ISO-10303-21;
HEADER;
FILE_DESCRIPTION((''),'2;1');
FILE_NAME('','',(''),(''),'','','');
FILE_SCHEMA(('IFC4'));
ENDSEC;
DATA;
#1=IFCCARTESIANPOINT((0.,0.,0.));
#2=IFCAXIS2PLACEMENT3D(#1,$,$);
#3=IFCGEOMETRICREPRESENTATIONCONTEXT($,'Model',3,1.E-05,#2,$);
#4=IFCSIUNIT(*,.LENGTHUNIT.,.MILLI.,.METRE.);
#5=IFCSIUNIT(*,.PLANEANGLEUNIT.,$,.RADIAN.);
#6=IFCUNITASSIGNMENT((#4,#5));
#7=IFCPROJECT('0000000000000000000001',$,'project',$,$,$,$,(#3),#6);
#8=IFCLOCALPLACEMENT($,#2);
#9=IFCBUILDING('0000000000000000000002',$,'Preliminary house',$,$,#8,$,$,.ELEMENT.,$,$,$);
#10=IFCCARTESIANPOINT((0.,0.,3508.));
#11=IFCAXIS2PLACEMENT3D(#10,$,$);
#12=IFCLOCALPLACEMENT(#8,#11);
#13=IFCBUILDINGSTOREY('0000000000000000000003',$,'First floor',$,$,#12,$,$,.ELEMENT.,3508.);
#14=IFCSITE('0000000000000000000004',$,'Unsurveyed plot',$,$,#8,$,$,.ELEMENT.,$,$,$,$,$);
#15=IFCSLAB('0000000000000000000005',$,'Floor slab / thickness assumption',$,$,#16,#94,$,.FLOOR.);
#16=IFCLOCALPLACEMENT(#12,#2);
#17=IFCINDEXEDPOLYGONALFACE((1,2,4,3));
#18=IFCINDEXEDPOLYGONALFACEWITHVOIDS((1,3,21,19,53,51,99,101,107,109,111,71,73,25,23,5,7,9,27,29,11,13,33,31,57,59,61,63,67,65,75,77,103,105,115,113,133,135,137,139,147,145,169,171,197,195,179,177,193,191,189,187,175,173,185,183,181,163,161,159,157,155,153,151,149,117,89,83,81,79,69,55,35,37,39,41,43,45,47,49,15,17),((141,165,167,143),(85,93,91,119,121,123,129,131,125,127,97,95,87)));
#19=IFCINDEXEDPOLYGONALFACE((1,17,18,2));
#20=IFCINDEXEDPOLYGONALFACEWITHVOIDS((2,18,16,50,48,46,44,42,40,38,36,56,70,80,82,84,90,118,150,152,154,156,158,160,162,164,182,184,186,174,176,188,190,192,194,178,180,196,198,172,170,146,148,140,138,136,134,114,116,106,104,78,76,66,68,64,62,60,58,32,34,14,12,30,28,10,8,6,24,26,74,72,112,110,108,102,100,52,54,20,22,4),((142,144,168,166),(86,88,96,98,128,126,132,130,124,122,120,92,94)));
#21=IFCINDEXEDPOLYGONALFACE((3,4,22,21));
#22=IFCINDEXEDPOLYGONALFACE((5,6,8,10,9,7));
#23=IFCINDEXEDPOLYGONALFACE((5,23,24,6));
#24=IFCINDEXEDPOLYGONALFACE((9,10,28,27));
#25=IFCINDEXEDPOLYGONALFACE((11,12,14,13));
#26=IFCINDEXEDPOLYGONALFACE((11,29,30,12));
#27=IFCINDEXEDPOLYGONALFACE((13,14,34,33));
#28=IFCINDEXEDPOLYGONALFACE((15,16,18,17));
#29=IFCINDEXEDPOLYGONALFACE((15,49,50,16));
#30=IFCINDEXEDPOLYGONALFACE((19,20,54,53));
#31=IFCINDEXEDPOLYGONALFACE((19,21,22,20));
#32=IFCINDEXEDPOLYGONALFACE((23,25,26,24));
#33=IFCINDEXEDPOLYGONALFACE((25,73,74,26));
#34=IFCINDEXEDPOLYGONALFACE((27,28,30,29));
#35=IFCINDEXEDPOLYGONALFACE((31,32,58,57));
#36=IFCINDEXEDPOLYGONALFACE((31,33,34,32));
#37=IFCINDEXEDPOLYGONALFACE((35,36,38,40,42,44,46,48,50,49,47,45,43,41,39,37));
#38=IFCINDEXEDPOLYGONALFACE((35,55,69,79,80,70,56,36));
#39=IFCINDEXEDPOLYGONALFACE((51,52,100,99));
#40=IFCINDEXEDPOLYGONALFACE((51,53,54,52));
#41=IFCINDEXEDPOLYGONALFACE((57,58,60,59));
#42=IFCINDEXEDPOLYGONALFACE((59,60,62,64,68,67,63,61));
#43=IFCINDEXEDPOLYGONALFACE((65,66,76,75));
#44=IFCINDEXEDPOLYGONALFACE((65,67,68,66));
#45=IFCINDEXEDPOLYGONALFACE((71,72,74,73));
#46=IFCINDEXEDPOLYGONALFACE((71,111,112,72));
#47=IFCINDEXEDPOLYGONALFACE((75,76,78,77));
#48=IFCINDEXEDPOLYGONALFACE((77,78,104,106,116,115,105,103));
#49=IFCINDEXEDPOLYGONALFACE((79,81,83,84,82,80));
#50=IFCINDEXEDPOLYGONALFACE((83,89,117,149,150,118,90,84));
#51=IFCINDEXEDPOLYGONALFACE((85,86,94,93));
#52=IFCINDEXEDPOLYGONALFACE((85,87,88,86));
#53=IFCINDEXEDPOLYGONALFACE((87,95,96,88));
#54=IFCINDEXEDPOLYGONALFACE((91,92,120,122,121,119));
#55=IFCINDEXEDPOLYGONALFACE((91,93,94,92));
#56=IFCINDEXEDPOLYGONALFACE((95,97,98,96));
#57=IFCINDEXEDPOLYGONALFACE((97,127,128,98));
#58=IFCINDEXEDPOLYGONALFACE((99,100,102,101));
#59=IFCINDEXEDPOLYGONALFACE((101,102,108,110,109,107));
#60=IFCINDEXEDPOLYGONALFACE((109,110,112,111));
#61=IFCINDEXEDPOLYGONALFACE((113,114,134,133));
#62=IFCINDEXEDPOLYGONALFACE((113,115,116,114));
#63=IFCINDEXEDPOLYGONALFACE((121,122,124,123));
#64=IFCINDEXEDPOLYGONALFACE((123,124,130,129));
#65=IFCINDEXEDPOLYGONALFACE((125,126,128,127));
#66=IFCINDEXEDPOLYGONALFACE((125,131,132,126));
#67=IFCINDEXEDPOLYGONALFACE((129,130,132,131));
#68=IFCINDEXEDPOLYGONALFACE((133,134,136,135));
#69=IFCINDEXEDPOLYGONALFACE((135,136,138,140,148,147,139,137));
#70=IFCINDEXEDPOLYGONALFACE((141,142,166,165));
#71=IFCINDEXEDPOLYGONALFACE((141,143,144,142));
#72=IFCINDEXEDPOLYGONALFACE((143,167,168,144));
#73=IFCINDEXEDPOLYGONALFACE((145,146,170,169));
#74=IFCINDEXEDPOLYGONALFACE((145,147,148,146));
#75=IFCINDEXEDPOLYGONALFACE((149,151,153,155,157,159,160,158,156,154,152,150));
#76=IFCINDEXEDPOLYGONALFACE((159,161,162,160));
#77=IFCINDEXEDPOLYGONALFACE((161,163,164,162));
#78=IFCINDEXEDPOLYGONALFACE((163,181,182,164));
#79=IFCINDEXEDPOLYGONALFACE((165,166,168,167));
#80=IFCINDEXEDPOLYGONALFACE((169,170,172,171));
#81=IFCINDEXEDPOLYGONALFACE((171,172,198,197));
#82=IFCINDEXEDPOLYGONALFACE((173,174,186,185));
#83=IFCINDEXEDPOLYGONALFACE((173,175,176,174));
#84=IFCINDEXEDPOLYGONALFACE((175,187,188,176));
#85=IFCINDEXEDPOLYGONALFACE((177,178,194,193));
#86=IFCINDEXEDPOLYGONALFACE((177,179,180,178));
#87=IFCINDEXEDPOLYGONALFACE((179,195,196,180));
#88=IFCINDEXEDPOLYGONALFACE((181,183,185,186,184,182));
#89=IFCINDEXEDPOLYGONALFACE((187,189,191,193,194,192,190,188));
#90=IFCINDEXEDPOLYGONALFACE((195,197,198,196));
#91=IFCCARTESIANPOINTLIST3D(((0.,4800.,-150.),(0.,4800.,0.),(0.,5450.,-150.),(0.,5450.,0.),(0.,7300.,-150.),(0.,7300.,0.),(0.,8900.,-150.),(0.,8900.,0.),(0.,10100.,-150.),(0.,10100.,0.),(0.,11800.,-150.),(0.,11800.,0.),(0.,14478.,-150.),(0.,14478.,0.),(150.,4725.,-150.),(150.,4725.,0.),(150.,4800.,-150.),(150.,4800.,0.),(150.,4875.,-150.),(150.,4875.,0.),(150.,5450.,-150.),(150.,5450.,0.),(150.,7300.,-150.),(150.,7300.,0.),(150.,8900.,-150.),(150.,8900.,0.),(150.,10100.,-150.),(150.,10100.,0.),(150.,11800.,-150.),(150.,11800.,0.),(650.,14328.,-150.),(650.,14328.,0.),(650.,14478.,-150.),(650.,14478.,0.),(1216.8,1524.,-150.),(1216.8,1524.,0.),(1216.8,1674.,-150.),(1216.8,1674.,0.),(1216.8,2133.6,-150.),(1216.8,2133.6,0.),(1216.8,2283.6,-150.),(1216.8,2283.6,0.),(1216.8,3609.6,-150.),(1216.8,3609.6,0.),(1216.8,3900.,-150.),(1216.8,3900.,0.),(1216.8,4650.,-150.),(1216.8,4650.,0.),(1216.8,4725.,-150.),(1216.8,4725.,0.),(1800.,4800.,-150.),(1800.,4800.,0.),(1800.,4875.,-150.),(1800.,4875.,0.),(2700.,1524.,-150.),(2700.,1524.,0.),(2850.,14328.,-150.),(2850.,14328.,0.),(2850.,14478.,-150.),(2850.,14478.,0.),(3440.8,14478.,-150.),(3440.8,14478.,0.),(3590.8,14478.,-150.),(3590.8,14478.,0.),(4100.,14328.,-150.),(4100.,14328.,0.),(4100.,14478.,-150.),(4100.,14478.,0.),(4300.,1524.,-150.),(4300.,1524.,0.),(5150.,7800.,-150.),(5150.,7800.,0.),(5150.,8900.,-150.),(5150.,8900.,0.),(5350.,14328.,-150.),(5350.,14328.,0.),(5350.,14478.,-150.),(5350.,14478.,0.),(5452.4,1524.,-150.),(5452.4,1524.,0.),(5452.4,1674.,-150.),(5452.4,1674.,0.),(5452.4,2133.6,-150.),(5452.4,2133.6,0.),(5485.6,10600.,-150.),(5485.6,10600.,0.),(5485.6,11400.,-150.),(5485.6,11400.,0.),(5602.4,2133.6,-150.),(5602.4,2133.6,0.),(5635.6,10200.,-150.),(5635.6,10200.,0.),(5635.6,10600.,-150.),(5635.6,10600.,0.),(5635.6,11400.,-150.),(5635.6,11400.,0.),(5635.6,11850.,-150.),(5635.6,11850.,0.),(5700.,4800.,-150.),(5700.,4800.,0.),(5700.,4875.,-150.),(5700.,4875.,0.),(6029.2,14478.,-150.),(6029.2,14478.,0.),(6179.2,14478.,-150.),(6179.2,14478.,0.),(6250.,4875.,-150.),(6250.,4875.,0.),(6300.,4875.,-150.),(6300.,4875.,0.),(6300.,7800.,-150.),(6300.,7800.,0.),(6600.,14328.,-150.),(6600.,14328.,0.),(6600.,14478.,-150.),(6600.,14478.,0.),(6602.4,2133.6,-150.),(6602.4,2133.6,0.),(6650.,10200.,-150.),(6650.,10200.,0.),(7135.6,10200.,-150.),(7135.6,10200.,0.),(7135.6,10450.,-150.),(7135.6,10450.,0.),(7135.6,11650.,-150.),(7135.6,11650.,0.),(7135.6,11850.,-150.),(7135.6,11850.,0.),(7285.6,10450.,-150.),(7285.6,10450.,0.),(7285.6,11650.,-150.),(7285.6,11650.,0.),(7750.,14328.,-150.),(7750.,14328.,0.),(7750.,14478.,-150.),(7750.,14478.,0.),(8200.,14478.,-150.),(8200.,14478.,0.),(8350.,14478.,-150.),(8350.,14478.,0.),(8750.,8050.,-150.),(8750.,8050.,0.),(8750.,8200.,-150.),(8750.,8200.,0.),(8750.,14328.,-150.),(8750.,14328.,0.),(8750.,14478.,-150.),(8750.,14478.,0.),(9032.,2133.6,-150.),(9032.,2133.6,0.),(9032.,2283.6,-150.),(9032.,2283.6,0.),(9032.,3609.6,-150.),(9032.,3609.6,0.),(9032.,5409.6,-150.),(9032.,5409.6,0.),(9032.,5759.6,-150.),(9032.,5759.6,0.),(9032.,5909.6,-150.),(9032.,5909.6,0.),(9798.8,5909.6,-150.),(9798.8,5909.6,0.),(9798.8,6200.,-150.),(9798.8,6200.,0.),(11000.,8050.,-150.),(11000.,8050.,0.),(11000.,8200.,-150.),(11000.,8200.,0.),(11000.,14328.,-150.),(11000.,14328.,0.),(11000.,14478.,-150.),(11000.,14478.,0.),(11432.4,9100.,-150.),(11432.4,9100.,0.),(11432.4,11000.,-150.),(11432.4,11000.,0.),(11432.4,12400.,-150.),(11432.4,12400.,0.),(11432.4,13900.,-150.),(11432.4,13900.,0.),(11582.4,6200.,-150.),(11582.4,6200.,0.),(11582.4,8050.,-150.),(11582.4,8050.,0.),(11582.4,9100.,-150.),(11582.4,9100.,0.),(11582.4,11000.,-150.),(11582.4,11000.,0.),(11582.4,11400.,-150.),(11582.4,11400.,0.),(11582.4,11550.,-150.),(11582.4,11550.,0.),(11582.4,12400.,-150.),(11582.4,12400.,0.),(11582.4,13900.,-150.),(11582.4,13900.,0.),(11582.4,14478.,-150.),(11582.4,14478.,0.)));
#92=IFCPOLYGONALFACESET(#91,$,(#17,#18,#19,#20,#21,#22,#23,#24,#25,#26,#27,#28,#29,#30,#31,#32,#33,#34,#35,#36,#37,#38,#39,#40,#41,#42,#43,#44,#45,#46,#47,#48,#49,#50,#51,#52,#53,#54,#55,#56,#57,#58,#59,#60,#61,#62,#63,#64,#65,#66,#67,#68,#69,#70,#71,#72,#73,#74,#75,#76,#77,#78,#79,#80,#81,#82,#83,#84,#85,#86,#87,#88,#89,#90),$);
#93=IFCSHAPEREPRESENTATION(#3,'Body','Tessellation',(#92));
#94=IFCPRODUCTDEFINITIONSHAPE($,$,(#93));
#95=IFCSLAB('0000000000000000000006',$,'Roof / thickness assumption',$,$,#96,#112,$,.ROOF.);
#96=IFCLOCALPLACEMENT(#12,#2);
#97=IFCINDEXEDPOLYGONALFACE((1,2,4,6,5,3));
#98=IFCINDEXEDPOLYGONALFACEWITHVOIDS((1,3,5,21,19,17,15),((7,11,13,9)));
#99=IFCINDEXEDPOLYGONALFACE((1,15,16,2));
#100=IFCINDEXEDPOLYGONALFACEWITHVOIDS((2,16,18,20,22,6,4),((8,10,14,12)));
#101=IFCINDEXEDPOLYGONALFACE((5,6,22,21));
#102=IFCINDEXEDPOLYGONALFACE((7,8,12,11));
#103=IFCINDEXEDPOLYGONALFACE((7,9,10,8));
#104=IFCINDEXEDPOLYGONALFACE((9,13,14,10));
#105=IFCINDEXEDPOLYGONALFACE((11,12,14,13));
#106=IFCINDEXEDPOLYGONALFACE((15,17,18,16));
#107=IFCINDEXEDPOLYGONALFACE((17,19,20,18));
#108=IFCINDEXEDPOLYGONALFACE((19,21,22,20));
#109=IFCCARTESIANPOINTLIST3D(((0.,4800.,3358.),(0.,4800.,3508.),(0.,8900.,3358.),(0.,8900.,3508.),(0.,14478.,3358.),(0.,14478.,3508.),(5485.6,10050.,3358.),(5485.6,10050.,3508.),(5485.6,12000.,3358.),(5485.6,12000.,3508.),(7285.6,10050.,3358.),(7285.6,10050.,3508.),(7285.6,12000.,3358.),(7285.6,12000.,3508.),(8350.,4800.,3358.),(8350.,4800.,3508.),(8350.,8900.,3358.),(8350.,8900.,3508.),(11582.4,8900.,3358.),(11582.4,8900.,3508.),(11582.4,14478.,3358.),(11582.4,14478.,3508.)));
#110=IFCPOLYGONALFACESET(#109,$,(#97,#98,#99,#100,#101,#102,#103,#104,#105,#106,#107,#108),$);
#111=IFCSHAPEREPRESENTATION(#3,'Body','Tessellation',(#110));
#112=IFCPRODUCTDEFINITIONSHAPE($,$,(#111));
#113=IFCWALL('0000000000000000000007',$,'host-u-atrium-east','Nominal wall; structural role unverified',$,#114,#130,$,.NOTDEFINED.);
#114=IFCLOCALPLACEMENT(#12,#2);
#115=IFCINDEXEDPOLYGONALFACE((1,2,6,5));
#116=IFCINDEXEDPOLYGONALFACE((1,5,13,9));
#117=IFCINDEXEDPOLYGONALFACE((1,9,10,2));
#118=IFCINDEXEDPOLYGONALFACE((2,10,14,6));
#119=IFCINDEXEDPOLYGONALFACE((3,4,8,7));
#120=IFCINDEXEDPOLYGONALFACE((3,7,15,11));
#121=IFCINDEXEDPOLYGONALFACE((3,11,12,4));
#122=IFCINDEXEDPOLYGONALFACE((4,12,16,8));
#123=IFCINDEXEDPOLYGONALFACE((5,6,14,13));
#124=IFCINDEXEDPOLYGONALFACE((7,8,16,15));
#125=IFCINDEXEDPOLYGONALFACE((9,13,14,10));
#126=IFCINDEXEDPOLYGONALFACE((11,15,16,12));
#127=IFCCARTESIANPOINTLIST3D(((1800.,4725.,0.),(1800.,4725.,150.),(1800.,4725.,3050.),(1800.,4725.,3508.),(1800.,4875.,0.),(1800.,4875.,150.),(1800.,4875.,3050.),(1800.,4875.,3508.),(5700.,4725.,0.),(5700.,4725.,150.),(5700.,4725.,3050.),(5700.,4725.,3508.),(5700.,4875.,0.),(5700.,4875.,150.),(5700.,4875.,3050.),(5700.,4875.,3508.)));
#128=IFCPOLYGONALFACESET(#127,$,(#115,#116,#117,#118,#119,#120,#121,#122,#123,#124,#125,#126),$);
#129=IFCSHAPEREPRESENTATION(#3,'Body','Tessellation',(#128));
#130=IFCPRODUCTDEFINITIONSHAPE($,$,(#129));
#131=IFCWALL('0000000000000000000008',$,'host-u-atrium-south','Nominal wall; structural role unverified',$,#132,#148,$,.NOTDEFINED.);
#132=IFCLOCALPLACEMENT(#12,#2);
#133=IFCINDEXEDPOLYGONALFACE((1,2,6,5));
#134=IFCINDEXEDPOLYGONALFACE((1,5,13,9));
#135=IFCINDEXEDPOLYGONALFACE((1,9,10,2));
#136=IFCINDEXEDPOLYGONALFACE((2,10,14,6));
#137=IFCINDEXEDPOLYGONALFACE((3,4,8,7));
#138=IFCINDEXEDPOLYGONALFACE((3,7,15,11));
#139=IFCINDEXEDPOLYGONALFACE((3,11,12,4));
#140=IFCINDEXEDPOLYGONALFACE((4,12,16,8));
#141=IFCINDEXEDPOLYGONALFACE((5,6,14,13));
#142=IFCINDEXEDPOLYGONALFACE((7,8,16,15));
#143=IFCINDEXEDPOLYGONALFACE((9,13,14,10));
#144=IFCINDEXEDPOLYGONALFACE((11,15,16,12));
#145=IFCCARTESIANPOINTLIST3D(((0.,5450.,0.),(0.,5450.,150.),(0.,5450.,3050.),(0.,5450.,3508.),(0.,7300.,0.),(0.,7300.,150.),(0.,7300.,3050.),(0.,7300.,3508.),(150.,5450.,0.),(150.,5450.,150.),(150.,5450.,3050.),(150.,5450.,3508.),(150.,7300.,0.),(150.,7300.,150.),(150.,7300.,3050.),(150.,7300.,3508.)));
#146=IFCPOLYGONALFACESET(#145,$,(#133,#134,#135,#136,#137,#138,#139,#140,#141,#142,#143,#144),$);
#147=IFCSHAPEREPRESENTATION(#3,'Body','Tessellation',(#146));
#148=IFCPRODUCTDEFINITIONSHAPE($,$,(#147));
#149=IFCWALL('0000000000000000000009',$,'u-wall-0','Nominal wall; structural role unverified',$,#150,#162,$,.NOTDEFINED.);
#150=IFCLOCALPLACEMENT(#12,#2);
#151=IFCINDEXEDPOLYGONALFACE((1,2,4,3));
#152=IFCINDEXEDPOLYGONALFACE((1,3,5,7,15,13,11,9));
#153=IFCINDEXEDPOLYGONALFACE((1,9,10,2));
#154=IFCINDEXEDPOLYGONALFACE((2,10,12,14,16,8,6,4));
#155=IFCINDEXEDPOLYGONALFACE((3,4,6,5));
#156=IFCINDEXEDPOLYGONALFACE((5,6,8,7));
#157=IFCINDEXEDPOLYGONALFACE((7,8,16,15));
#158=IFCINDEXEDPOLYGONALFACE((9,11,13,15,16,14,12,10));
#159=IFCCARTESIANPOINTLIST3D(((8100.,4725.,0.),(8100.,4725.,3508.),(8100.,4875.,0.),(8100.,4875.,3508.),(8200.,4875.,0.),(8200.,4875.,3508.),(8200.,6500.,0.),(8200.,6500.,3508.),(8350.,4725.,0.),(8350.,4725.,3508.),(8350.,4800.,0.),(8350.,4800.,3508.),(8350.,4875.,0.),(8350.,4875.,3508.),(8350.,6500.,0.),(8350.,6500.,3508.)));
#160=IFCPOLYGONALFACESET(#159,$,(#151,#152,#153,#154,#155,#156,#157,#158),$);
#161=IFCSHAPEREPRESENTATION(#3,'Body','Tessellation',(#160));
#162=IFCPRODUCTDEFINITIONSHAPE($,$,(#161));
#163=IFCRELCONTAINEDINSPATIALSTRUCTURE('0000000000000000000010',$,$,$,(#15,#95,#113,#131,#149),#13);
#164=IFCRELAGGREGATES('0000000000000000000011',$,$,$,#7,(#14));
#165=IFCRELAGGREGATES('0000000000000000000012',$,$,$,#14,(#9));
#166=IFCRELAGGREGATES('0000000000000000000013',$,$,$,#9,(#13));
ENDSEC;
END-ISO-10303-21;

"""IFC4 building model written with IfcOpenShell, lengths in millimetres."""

from ifc_helpers import new_model, si_unit, frame, origin, place, context, project, spatial, polyline, outline, extrude, element, save


model = new_model("IFC4")

# Units and contexts
model_context = context("Model", 3, precision=1e-05, world=origin())
ifc_project = project(units=[si_unit("LENGTHUNIT", "METRE", prefix="MILLI"), si_unit("PLANEANGLEUNIT", "RADIAN")], contexts=[model_context])

# Site, building, storey
placement_1 = place(None, origin())
site = spatial("IfcSite", under=ifc_project, at=placement_1, Name="Unsurveyed plot", CompositionType="ELEMENT")
building = spatial("IfcBuilding", under=site, at=placement_1, Name="Preliminary house", CompositionType="ELEMENT")
placement_2 = place(placement_1, frame((0.0, 0.0, 3508.0)))
storey = spatial("IfcBuildingStorey", under=building, at=placement_2, Name="First floor", CompositionType="ELEMENT", Elevation=3508.0)

# Slabs
element("IfcSlab", 1, at=placement_2, inside=storey, Name="Floor slab / thickness assumption", PredefinedType="FLOOR", context=model_context, shape_type="SweptSolid", body=[
    extrude(outline(polyline([(9032.0, 3609.6), (9032.0, 2283.6), (9032.0, 2133.6), (6602.4, 2133.6), (5602.4, 2133.6), (5452.4, 2133.6), (5452.4, 1674.0), (5452.4, 1524.0), (4300.0, 1524.0), (2700.0, 1524.0), (1216.8, 1524.0), (1216.8, 1674.0), (1216.8, 2133.6), (1216.8, 2283.6), (1216.8, 3609.6), (1216.8, 3900.0), (1216.8, 4650.0), (1216.8, 4725.0), (150.0, 4725.0), (150.0, 4800.0), (0.0, 4800.0), (0.0, 5450.0), (150.0, 5450.0), (150.0, 4875.0), (1800.0, 4875.0), (1800.0, 4800.0), (5700.0, 4800.0), (5700.0, 4875.0), (6250.0, 4875.0), (6300.0, 4875.0), (6300.0, 7800.0), (5150.0, 7800.0), (5150.0, 8900.0), (150.0, 8900.0), (150.0, 7300.0), (0.0, 7300.0), (0.0, 8900.0), (0.0, 10100.0), (150.0, 10100.0), (150.0, 11800.0), (0.0, 11800.0), (0.0, 14478.0), (650.0, 14478.0), (650.0, 14328.0), (2850.0, 14328.0), (2850.0, 14478.0), (3440.8, 14478.0), (3590.8, 14478.0), (4100.0, 14478.0), (4100.0, 14328.0), (5350.0, 14328.0), (5350.0, 14478.0), (6029.2, 14478.0), (6179.2, 14478.0), (6600.0, 14478.0), (6600.0, 14328.0), (7750.0, 14328.0), (7750.0, 14478.0), (8200.0, 14478.0), (8350.0, 14478.0), (8750.0, 14478.0), (8750.0, 14328.0), (11000.0, 14328.0), (11000.0, 14478.0), (11582.4, 14478.0), (11582.4, 13900.0), (11432.4, 13900.0), (11432.4, 12400.0), (11582.4, 12400.0), (11582.4, 11550.0), (11582.4, 11400.0), (11582.4, 11000.0), (11432.4, 11000.0), (11432.4, 9100.0), (11582.4, 9100.0), (11582.4, 8050.0), (11582.4, 6200.0), (9798.8, 6200.0), (9798.8, 5909.6), (9032.0, 5909.6), (9032.0, 5759.6), (9032.0, 5409.6), (9032.0, 3609.6)]), holes=[polyline([(11000.0, 8050.0), (11000.0, 8200.0), (8750.0, 8200.0), (8750.0, 8050.0), (11000.0, 8050.0)]), polyline([(7135.6, 11650.0), (7135.6, 11850.0), (5635.6, 11850.0), (5635.6, 11400.0), (5485.6, 11400.0), (5485.6, 10600.0), (5635.6, 10600.0), (5635.6, 10200.0), (6650.0, 10200.0), (7135.6, 10200.0), (7135.6, 10450.0), (7285.6, 10450.0), (7285.6, 11650.0), (7135.6, 11650.0)])]), frame((0.0, 0.0, -150.0)), (0.0, 0.0, 1.0), 150.0),
])
element("IfcSlab", 2, at=placement_2, inside=storey, Name="Roof / thickness assumption", PredefinedType="ROOF", context=model_context, shape_type="SweptSolid", body=[
    extrude(outline(polyline([(0.0, 4800.0), (0.0, 8900.0), (0.0, 14478.0), (11582.4, 14478.0), (11582.4, 8900.0), (8350.0, 8900.0), (8350.0, 4800.0), (0.0, 4800.0)]), holes=[polyline([(7285.6, 12000.0), (5485.6, 12000.0), (5485.6, 10050.0), (7285.6, 10050.0), (7285.6, 12000.0)])]), frame((0.0, 0.0, 3358.0)), (0.0, 0.0, 1.0), 150.0),
])

# Walls, openings
wall_1 = element("IfcWall", 3, at=placement_2, inside=storey, Name="host-u-atrium-east", Description="Nominal wall; structural role unverified", PredefinedType="NOTDEFINED", context=model_context, shape_type="SweptSolid", body=[
    extrude(outline(polyline([(5700.0, 4875.0), (5700.0, 4725.0), (1800.0, 4725.0), (1800.0, 4875.0), (5700.0, 4875.0)])), origin(), (0.0, 0.0, 1.0), 3508.0),
])
element("IfcOpeningElement", 4, at=placement_2, cuts=wall_1, PredefinedType="OPENING", context=model_context, shape_type="SweptSolid", body=[
    extrude(outline(polyline([(1800.0, 4350.0), (5700.0, 4350.0), (5700.0, 5250.0), (1800.0, 5250.0), (1800.0, 4350.0)])), frame((0.0, 0.0, 150.0)), (0.0, 0.0, 1.0), 2900.0),
])
wall_2 = element("IfcWall", 5, at=placement_2, inside=storey, Name="host-u-atrium-south", Description="Nominal wall; structural role unverified", PredefinedType="NOTDEFINED", context=model_context, shape_type="SweptSolid", body=[
    extrude(outline(polyline([(0.0, 7300.0), (150.0, 7300.0), (150.0, 5450.0), (0.0, 5450.0), (0.0, 7300.0)])), origin(), (0.0, 0.0, 1.0), 3508.0),
])
element("IfcOpeningElement", 6, at=placement_2, cuts=wall_2, PredefinedType="OPENING", context=model_context, shape_type="SweptSolid", body=[
    extrude(outline(polyline([(525.0, 5450.0), (525.0, 7300.0), (-375.0, 7300.0), (-375.0, 5450.0), (525.0, 5450.0)])), frame((0.0, 0.0, 150.0)), (0.0, 0.0, 1.0), 2900.0),
])

# Wall
element("IfcWall", 7, at=placement_2, inside=storey, Name="u-wall-0", Description="Nominal wall; structural role unverified", PredefinedType="NOTDEFINED", context=model_context, shape_type="SweptSolid", body=[
    extrude(outline(polyline([(8350.0, 4875.0), (8350.0, 4800.0), (8350.0, 4725.0), (8100.0, 4725.0), (8100.0, 4875.0), (8200.0, 4875.0), (8200.0, 6500.0), (8350.0, 6500.0), (8350.0, 4875.0)])), origin(), (0.0, 0.0, 1.0), 3508.0),
])

save(model, "model.ifc")
